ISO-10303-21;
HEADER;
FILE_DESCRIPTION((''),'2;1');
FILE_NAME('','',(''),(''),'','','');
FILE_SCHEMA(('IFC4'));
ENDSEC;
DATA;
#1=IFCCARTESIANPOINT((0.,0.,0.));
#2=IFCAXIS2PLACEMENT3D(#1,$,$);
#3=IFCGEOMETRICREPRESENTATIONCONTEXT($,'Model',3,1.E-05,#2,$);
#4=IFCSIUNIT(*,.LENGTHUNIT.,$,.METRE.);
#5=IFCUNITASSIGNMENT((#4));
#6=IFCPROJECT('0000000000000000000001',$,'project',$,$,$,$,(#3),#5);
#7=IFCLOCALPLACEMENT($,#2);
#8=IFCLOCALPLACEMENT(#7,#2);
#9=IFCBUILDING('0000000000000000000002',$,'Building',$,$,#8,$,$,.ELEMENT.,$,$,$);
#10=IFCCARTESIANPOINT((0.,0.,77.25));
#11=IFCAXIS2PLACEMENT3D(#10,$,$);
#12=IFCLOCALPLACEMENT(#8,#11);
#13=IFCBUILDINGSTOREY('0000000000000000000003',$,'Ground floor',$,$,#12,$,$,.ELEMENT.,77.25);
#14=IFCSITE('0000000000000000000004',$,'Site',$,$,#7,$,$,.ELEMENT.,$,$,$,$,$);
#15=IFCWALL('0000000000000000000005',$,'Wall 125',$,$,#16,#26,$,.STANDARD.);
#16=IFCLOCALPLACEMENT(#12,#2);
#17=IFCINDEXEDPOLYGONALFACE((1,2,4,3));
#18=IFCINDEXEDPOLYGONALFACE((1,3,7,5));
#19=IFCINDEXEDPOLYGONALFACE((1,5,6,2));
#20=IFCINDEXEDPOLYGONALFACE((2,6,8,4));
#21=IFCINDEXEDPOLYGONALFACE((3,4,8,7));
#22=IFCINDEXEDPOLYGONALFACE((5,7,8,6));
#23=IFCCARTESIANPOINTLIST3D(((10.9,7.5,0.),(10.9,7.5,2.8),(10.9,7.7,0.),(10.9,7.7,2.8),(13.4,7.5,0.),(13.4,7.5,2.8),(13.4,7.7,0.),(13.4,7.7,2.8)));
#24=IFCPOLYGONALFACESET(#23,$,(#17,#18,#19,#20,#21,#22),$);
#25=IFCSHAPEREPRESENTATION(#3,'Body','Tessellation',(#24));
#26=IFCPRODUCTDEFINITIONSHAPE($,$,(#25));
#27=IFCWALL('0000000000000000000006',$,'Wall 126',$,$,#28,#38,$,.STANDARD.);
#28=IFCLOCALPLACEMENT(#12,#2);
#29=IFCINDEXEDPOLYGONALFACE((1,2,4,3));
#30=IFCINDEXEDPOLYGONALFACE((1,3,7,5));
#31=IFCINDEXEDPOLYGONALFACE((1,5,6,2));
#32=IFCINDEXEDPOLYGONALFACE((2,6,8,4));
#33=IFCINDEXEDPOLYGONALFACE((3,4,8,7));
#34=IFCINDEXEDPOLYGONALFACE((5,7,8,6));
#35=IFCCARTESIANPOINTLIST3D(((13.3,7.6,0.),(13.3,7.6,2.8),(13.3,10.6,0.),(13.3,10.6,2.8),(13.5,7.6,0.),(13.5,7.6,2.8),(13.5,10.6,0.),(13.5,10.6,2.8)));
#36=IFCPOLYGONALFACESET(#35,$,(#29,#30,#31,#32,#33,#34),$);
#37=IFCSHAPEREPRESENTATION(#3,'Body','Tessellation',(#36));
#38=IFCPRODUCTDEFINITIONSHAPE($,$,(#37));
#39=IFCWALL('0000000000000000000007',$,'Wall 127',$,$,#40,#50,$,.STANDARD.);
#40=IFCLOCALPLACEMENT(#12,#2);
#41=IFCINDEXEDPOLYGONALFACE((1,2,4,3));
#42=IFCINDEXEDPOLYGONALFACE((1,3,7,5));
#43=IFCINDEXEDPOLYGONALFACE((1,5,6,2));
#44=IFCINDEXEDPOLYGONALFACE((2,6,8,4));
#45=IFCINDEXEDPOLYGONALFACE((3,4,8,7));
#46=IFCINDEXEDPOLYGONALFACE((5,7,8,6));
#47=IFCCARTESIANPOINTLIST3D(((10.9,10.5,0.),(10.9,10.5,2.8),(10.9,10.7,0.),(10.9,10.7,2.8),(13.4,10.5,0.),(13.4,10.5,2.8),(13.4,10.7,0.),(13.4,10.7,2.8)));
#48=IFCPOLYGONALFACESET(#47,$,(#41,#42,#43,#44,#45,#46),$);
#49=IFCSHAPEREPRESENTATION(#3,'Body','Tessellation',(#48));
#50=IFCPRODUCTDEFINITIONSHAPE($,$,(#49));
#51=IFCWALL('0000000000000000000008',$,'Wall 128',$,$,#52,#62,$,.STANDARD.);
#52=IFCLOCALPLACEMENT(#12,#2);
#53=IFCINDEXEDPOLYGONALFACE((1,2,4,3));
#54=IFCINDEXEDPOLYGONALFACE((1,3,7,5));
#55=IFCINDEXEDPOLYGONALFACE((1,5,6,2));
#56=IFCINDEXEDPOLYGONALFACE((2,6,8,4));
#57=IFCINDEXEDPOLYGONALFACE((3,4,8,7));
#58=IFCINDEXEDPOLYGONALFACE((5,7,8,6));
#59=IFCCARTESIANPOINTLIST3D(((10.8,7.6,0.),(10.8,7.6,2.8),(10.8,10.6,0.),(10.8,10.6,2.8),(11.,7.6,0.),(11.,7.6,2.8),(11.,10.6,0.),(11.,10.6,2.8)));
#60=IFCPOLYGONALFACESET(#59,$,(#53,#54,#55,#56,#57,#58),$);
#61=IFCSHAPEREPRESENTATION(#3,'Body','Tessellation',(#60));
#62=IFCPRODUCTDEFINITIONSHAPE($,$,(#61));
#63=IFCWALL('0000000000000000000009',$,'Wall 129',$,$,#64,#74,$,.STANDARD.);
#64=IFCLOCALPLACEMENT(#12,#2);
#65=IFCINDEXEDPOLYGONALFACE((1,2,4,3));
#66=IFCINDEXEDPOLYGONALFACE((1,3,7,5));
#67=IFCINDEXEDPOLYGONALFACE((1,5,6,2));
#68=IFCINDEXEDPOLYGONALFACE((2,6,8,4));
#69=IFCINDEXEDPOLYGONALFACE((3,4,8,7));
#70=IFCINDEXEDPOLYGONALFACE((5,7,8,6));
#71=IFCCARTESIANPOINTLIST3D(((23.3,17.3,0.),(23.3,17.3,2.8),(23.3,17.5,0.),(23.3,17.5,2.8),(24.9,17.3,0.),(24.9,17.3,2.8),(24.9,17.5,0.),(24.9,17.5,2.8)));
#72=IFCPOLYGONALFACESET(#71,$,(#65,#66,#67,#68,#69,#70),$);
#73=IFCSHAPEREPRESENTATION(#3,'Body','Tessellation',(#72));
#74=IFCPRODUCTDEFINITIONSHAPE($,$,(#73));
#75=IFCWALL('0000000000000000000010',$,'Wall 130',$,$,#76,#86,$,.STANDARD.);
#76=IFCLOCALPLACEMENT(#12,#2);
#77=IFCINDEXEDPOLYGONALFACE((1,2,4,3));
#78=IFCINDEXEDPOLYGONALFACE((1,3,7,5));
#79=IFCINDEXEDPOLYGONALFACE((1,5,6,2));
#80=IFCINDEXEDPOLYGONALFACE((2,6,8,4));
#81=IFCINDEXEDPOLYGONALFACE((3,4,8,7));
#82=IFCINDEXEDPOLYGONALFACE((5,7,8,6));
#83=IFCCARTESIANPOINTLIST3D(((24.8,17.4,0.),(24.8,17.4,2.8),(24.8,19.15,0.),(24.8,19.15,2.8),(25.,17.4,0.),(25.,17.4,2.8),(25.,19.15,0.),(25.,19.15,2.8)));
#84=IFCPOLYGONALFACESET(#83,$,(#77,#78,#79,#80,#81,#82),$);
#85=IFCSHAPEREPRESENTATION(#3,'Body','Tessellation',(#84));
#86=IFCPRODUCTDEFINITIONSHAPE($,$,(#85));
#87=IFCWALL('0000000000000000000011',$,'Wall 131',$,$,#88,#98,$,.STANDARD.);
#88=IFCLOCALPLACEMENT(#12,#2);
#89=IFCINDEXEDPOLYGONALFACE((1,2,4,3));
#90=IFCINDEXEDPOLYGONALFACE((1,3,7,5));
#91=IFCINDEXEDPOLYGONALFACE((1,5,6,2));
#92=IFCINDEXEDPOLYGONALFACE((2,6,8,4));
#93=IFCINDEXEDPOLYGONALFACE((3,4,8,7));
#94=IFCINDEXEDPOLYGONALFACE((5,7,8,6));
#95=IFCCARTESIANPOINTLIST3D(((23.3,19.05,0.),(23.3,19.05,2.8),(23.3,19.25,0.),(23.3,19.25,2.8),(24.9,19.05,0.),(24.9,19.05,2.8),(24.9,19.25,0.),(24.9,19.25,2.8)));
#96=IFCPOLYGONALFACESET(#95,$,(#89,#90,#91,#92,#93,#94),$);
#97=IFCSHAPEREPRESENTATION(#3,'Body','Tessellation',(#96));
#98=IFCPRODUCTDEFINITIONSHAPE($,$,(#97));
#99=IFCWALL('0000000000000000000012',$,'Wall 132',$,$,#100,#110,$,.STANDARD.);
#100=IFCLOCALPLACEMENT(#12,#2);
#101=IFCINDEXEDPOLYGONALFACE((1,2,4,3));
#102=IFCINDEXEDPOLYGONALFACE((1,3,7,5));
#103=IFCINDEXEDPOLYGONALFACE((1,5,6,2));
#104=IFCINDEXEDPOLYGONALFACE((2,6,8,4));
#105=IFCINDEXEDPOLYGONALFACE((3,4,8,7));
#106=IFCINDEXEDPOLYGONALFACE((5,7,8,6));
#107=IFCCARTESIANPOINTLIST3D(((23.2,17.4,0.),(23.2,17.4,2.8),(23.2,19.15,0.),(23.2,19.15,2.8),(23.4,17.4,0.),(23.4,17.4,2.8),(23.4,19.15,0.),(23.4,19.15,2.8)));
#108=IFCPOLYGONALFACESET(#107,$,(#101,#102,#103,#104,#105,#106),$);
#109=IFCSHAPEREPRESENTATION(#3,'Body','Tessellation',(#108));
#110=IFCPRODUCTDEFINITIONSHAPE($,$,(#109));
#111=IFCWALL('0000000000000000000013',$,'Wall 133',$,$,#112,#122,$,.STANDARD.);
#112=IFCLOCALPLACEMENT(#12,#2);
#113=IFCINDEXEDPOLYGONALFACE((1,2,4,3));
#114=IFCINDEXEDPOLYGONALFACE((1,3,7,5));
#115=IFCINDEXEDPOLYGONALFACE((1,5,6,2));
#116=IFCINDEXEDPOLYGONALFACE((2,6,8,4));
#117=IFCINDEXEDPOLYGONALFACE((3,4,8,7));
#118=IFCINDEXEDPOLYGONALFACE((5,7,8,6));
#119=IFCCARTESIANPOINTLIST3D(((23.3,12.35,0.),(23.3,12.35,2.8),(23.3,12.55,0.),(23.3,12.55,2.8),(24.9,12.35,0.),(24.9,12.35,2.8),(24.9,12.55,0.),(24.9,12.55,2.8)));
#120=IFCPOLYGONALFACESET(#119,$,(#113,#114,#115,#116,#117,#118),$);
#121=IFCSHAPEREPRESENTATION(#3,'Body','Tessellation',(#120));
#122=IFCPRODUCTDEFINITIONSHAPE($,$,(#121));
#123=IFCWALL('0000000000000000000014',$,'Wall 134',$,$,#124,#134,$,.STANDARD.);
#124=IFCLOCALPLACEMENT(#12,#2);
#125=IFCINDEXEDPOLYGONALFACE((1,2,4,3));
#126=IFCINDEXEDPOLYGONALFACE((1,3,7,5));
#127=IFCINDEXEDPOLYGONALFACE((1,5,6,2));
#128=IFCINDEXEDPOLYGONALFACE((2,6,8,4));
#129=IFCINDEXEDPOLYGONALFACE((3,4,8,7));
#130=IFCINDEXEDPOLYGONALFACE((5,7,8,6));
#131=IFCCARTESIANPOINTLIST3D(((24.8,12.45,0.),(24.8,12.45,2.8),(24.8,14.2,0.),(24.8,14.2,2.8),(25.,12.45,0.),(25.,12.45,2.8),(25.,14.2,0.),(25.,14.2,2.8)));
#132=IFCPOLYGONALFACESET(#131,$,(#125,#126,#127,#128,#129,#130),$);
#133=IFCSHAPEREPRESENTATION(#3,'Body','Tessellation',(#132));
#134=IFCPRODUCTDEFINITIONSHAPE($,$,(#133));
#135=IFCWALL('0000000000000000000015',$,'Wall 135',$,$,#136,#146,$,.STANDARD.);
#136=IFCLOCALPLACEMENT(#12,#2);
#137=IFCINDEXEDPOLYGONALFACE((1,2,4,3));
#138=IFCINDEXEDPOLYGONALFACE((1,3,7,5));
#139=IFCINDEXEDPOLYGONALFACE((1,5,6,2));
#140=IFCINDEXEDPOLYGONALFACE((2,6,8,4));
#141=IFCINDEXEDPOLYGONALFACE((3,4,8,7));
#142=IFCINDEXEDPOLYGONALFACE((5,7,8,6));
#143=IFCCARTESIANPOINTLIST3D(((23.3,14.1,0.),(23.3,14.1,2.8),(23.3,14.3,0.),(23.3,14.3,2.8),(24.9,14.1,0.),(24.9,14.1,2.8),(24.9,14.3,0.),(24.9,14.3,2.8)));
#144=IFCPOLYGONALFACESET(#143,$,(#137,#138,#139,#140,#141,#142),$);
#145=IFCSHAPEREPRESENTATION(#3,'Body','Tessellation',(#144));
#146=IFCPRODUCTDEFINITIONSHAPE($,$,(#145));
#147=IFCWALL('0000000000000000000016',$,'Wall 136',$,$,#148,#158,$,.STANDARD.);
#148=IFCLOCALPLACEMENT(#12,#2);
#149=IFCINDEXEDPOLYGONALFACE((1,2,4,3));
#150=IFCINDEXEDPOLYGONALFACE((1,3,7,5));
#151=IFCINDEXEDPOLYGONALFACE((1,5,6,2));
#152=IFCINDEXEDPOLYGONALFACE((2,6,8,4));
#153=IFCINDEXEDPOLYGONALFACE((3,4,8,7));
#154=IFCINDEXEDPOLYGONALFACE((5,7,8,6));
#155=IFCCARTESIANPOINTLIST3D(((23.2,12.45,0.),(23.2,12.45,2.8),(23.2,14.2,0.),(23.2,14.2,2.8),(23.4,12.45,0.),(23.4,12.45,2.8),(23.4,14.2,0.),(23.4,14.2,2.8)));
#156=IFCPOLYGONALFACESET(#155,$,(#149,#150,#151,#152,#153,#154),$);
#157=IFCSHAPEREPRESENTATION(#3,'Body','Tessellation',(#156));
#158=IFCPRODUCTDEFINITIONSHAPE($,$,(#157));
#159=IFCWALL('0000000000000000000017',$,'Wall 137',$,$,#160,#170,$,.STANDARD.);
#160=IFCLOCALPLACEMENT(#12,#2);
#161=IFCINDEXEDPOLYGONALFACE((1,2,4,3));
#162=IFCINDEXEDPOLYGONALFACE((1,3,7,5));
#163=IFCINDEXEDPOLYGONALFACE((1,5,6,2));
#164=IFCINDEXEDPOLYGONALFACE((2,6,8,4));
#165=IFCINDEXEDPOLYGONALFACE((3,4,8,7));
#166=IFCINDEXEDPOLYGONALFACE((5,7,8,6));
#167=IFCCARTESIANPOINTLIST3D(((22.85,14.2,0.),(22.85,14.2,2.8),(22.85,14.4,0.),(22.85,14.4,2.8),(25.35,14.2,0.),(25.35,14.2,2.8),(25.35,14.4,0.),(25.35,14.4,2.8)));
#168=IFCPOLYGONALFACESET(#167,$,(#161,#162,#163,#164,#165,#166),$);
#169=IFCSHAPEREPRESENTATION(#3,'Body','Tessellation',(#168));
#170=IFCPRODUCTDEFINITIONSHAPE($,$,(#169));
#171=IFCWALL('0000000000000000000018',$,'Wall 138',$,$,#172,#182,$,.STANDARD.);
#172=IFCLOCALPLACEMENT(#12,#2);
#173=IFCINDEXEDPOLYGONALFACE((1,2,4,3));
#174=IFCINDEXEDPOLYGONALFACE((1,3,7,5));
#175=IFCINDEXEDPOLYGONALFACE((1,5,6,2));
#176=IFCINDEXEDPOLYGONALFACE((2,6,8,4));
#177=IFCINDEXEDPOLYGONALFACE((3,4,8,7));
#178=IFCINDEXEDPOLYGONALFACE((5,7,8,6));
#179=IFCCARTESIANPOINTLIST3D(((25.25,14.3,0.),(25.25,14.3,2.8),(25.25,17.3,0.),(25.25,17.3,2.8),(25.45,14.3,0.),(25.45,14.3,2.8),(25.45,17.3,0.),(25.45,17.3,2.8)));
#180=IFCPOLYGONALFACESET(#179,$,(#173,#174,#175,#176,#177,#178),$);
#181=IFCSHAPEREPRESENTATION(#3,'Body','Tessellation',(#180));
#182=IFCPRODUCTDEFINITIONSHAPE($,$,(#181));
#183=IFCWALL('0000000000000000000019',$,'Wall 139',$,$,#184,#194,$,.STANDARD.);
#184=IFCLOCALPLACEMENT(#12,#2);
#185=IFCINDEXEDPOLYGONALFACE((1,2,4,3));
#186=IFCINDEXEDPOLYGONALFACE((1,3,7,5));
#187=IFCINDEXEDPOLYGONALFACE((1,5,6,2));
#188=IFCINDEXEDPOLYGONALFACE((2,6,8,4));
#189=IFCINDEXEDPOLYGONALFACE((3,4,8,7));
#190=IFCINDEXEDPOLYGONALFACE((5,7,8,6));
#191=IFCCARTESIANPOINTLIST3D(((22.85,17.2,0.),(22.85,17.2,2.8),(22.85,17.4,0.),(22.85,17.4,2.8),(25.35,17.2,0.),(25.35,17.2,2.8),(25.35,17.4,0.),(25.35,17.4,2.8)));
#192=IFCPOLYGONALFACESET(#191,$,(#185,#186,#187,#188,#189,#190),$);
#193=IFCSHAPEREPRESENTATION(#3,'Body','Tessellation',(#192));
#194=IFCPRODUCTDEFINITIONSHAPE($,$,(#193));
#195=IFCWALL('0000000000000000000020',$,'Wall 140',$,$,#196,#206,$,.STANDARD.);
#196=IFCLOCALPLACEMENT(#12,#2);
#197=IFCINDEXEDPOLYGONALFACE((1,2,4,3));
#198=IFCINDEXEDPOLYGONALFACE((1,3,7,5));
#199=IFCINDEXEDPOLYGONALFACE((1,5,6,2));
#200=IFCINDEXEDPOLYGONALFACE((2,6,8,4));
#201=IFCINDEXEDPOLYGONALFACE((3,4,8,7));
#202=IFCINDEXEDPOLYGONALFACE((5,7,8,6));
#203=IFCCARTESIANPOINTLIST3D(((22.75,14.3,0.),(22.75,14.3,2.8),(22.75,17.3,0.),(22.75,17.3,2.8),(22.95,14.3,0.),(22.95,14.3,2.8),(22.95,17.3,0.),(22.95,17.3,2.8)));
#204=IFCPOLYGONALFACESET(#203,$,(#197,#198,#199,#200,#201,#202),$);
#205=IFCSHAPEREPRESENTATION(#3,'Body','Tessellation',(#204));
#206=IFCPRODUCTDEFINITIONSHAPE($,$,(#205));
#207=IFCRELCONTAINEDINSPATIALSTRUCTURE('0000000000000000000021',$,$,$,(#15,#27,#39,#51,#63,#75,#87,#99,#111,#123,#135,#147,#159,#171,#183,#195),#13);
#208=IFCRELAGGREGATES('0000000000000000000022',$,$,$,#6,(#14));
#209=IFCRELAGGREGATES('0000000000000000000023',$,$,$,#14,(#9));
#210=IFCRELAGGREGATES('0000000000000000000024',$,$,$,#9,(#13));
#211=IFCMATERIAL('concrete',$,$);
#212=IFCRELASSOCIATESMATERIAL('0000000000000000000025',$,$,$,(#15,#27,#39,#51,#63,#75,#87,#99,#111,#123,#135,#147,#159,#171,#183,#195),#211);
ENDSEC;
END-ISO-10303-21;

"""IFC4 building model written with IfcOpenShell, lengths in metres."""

from ifc_helpers import new_model, si_unit, frame, frame_2d, origin, place, context, project, spatial, rectangle, extrude, material, element, save


model = new_model("IFC4")

# Units and contexts
model_context = context("Model", 3, precision=1e-05, world=origin())
ifc_project = project(units=[si_unit("LENGTHUNIT", "METRE")], contexts=[model_context])

# Site, building, storey
site_placement = place(None, origin())
site = spatial("IfcSite", under=ifc_project, at=site_placement, Name="Site", CompositionType="ELEMENT")
building_placement = place(site_placement, origin())
building = spatial("IfcBuilding", under=site, at=building_placement, Name="Building", CompositionType="ELEMENT")
storey_placement = place(building_placement, frame((0.0, 0.0, 77.25)))
storey = spatial("IfcBuildingStorey", under=building, at=storey_placement, Name="Ground floor", CompositionType="ELEMENT", Elevation=77.25)

# Shared definitions
ifc_material = material(Name="concrete")

# Walls
wall_1_placement = place(storey_placement, frame((10.9, 7.6, 0.0), z_axis=(0.0, 0.0, 1.0), x_axis=(1.0, 0.0, 0.0)))
element("IfcWall", 1, at=wall_1_placement, inside=storey, material=ifc_material, Name="Wall 125", PredefinedType="STANDARD", context=model_context, shape_type="SweptSolid", body=[
    extrude(rectangle(XDim=2.5, YDim=0.2, at=frame_2d((1.25, 0.0))), origin(), (0.0, 0.0, 1.0), 2.8),
])
wall_2_placement = place(storey_placement, frame((13.4, 7.6, 0.0), z_axis=(0.0, 0.0, 1.0), x_axis=(0.0, 1.0, 0.0)))
element("IfcWall", 2, at=wall_2_placement, inside=storey, material=ifc_material, Name="Wall 126", PredefinedType="STANDARD", context=model_context, shape_type="SweptSolid", body=[
    extrude(rectangle(XDim=3.0, YDim=0.2, at=frame_2d((1.5, 0.0))), origin(), (0.0, 0.0, 1.0), 2.8),
])
wall_3_placement = place(storey_placement, frame((13.4, 10.6, 0.0), z_axis=(0.0, 0.0, 1.0), x_axis=(-1.0, 0.0, 0.0)))
element("IfcWall", 3, at=wall_3_placement, inside=storey, material=ifc_material, Name="Wall 127", PredefinedType="STANDARD", context=model_context, shape_type="SweptSolid", body=[
    extrude(rectangle(XDim=2.5, YDim=0.2, at=frame_2d((1.25, 0.0))), origin(), (0.0, 0.0, 1.0), 2.8),
])
wall_4_placement = place(storey_placement, frame((10.9, 10.6, 0.0), z_axis=(0.0, 0.0, 1.0), x_axis=(0.0, -1.0, 0.0)))
element("IfcWall", 4, at=wall_4_placement, inside=storey, material=ifc_material, Name="Wall 128", PredefinedType="STANDARD", context=model_context, shape_type="SweptSolid", body=[
    extrude(rectangle(XDim=3.0, YDim=0.2, at=frame_2d((1.5, 0.0))), origin(), (0.0, 0.0, 1.0), 2.8),
])
wall_5_placement = place(storey_placement, frame((23.3, 17.4, 0.0), z_axis=(0.0, 0.0, 1.0), x_axis=(1.0, 0.0, 0.0)))
element("IfcWall", 5, at=wall_5_placement, inside=storey, material=ifc_material, Name="Wall 129", PredefinedType="STANDARD", context=model_context, shape_type="SweptSolid", body=[
    extrude(rectangle(XDim=1.6, YDim=0.2, at=frame_2d((0.8, 0.0))), origin(), (0.0, 0.0, 1.0), 2.8),
])
wall_6_placement = place(storey_placement, frame((24.9, 17.4, 0.0), z_axis=(0.0, 0.0, 1.0), x_axis=(0.0, 1.0, 0.0)))
element("IfcWall", 6, at=wall_6_placement, inside=storey, material=ifc_material, Name="Wall 130", PredefinedType="STANDARD", context=model_context, shape_type="SweptSolid", body=[
    extrude(rectangle(XDim=1.75, YDim=0.2, at=frame_2d((0.875, 0.0))), origin(), (0.0, 0.0, 1.0), 2.8),
])
wall_7_placement = place(storey_placement, frame((24.9, 19.15, 0.0), z_axis=(0.0, 0.0, 1.0), x_axis=(-1.0, 0.0, 0.0)))
element("IfcWall", 7, at=wall_7_placement, inside=storey, material=ifc_material, Name="Wall 131", PredefinedType="STANDARD", context=model_context, shape_type="SweptSolid", body=[
    extrude(rectangle(XDim=1.6, YDim=0.2, at=frame_2d((0.8, 0.0))), origin(), (0.0, 0.0, 1.0), 2.8),
])
wall_8_placement = place(storey_placement, frame((23.3, 19.15, 0.0), z_axis=(0.0, 0.0, 1.0), x_axis=(0.0, -1.0, 0.0)))
element("IfcWall", 8, at=wall_8_placement, inside=storey, material=ifc_material, Name="Wall 132", PredefinedType="STANDARD", context=model_context, shape_type="SweptSolid", body=[
    extrude(rectangle(XDim=1.75, YDim=0.2, at=frame_2d((0.875, 0.0))), origin(), (0.0, 0.0, 1.0), 2.8),
])
wall_9_placement = place(storey_placement, frame((23.3, 12.45, 0.0), z_axis=(0.0, 0.0, 1.0), x_axis=(1.0, 0.0, 0.0)))
element("IfcWall", 9, at=wall_9_placement, inside=storey, material=ifc_material, Name="Wall 133", PredefinedType="STANDARD", context=model_context, shape_type="SweptSolid", body=[
    extrude(rectangle(XDim=1.6, YDim=0.2, at=frame_2d((0.8, 0.0))), origin(), (0.0, 0.0, 1.0), 2.8),
])
wall_10_placement = place(storey_placement, frame((24.9, 12.45, 0.0), z_axis=(0.0, 0.0, 1.0), x_axis=(0.0, 1.0, 0.0)))
element("IfcWall", 10, at=wall_10_placement, inside=storey, material=ifc_material, Name="Wall 134", PredefinedType="STANDARD", context=model_context, shape_type="SweptSolid", body=[
    extrude(rectangle(XDim=1.75, YDim=0.2, at=frame_2d((0.875, 0.0))), origin(), (0.0, 0.0, 1.0), 2.8),
])
wall_11_placement = place(storey_placement, frame((24.9, 14.2, 0.0), z_axis=(0.0, 0.0, 1.0), x_axis=(-1.0, 0.0, 0.0)))
element("IfcWall", 11, at=wall_11_placement, inside=storey, material=ifc_material, Name="Wall 135", PredefinedType="STANDARD", context=model_context, shape_type="SweptSolid", body=[
    extrude(rectangle(XDim=1.6, YDim=0.2, at=frame_2d((0.8, 0.0))), origin(), (0.0, 0.0, 1.0), 2.8),
])
wall_12_placement = place(storey_placement, frame((23.3, 14.2, 0.0), z_axis=(0.0, 0.0, 1.0), x_axis=(0.0, -1.0, 0.0)))
element("IfcWall", 12, at=wall_12_placement, inside=storey, material=ifc_material, Name="Wall 136", PredefinedType="STANDARD", context=model_context, shape_type="SweptSolid", body=[
    extrude(rectangle(XDim=1.75, YDim=0.2, at=frame_2d((0.875, 0.0))), origin(), (0.0, 0.0, 1.0), 2.8),
])
wall_13_placement = place(storey_placement, frame((22.85, 14.3, 0.0), z_axis=(0.0, 0.0, 1.0), x_axis=(1.0, 0.0, 0.0)))
element("IfcWall", 13, at=wall_13_placement, inside=storey, material=ifc_material, Name="Wall 137", PredefinedType="STANDARD", context=model_context, shape_type="SweptSolid", body=[
    extrude(rectangle(XDim=2.5, YDim=0.2, at=frame_2d((1.25, 0.0))), origin(), (0.0, 0.0, 1.0), 2.8),
])
wall_14_placement = place(storey_placement, frame((25.35, 14.3, 0.0), z_axis=(0.0, 0.0, 1.0), x_axis=(0.0, 1.0, 0.0)))
element("IfcWall", 14, at=wall_14_placement, inside=storey, material=ifc_material, Name="Wall 138", PredefinedType="STANDARD", context=model_context, shape_type="SweptSolid", body=[
    extrude(rectangle(XDim=3.0, YDim=0.2, at=frame_2d((1.5, 0.0))), origin(), (0.0, 0.0, 1.0), 2.8),
])
wall_15_placement = place(storey_placement, frame((25.35, 17.3, 0.0), z_axis=(0.0, 0.0, 1.0), x_axis=(-1.0, 0.0, 0.0)))
element("IfcWall", 15, at=wall_15_placement, inside=storey, material=ifc_material, Name="Wall 139", PredefinedType="STANDARD", context=model_context, shape_type="SweptSolid", body=[
    extrude(rectangle(XDim=2.5, YDim=0.2, at=frame_2d((1.25, 0.0))), origin(), (0.0, 0.0, 1.0), 2.8),
])
wall_16_placement = place(storey_placement, frame((22.85, 17.3, 0.0), z_axis=(0.0, 0.0, 1.0), x_axis=(0.0, -1.0, 0.0)))
element("IfcWall", 16, at=wall_16_placement, inside=storey, material=ifc_material, Name="Wall 140", PredefinedType="STANDARD", context=model_context, shape_type="SweptSolid", body=[
    extrude(rectangle(XDim=3.0, YDim=0.2, at=frame_2d((1.5, 0.0))), origin(), (0.0, 0.0, 1.0), 2.8),
])

save(model, "model.ifc")
